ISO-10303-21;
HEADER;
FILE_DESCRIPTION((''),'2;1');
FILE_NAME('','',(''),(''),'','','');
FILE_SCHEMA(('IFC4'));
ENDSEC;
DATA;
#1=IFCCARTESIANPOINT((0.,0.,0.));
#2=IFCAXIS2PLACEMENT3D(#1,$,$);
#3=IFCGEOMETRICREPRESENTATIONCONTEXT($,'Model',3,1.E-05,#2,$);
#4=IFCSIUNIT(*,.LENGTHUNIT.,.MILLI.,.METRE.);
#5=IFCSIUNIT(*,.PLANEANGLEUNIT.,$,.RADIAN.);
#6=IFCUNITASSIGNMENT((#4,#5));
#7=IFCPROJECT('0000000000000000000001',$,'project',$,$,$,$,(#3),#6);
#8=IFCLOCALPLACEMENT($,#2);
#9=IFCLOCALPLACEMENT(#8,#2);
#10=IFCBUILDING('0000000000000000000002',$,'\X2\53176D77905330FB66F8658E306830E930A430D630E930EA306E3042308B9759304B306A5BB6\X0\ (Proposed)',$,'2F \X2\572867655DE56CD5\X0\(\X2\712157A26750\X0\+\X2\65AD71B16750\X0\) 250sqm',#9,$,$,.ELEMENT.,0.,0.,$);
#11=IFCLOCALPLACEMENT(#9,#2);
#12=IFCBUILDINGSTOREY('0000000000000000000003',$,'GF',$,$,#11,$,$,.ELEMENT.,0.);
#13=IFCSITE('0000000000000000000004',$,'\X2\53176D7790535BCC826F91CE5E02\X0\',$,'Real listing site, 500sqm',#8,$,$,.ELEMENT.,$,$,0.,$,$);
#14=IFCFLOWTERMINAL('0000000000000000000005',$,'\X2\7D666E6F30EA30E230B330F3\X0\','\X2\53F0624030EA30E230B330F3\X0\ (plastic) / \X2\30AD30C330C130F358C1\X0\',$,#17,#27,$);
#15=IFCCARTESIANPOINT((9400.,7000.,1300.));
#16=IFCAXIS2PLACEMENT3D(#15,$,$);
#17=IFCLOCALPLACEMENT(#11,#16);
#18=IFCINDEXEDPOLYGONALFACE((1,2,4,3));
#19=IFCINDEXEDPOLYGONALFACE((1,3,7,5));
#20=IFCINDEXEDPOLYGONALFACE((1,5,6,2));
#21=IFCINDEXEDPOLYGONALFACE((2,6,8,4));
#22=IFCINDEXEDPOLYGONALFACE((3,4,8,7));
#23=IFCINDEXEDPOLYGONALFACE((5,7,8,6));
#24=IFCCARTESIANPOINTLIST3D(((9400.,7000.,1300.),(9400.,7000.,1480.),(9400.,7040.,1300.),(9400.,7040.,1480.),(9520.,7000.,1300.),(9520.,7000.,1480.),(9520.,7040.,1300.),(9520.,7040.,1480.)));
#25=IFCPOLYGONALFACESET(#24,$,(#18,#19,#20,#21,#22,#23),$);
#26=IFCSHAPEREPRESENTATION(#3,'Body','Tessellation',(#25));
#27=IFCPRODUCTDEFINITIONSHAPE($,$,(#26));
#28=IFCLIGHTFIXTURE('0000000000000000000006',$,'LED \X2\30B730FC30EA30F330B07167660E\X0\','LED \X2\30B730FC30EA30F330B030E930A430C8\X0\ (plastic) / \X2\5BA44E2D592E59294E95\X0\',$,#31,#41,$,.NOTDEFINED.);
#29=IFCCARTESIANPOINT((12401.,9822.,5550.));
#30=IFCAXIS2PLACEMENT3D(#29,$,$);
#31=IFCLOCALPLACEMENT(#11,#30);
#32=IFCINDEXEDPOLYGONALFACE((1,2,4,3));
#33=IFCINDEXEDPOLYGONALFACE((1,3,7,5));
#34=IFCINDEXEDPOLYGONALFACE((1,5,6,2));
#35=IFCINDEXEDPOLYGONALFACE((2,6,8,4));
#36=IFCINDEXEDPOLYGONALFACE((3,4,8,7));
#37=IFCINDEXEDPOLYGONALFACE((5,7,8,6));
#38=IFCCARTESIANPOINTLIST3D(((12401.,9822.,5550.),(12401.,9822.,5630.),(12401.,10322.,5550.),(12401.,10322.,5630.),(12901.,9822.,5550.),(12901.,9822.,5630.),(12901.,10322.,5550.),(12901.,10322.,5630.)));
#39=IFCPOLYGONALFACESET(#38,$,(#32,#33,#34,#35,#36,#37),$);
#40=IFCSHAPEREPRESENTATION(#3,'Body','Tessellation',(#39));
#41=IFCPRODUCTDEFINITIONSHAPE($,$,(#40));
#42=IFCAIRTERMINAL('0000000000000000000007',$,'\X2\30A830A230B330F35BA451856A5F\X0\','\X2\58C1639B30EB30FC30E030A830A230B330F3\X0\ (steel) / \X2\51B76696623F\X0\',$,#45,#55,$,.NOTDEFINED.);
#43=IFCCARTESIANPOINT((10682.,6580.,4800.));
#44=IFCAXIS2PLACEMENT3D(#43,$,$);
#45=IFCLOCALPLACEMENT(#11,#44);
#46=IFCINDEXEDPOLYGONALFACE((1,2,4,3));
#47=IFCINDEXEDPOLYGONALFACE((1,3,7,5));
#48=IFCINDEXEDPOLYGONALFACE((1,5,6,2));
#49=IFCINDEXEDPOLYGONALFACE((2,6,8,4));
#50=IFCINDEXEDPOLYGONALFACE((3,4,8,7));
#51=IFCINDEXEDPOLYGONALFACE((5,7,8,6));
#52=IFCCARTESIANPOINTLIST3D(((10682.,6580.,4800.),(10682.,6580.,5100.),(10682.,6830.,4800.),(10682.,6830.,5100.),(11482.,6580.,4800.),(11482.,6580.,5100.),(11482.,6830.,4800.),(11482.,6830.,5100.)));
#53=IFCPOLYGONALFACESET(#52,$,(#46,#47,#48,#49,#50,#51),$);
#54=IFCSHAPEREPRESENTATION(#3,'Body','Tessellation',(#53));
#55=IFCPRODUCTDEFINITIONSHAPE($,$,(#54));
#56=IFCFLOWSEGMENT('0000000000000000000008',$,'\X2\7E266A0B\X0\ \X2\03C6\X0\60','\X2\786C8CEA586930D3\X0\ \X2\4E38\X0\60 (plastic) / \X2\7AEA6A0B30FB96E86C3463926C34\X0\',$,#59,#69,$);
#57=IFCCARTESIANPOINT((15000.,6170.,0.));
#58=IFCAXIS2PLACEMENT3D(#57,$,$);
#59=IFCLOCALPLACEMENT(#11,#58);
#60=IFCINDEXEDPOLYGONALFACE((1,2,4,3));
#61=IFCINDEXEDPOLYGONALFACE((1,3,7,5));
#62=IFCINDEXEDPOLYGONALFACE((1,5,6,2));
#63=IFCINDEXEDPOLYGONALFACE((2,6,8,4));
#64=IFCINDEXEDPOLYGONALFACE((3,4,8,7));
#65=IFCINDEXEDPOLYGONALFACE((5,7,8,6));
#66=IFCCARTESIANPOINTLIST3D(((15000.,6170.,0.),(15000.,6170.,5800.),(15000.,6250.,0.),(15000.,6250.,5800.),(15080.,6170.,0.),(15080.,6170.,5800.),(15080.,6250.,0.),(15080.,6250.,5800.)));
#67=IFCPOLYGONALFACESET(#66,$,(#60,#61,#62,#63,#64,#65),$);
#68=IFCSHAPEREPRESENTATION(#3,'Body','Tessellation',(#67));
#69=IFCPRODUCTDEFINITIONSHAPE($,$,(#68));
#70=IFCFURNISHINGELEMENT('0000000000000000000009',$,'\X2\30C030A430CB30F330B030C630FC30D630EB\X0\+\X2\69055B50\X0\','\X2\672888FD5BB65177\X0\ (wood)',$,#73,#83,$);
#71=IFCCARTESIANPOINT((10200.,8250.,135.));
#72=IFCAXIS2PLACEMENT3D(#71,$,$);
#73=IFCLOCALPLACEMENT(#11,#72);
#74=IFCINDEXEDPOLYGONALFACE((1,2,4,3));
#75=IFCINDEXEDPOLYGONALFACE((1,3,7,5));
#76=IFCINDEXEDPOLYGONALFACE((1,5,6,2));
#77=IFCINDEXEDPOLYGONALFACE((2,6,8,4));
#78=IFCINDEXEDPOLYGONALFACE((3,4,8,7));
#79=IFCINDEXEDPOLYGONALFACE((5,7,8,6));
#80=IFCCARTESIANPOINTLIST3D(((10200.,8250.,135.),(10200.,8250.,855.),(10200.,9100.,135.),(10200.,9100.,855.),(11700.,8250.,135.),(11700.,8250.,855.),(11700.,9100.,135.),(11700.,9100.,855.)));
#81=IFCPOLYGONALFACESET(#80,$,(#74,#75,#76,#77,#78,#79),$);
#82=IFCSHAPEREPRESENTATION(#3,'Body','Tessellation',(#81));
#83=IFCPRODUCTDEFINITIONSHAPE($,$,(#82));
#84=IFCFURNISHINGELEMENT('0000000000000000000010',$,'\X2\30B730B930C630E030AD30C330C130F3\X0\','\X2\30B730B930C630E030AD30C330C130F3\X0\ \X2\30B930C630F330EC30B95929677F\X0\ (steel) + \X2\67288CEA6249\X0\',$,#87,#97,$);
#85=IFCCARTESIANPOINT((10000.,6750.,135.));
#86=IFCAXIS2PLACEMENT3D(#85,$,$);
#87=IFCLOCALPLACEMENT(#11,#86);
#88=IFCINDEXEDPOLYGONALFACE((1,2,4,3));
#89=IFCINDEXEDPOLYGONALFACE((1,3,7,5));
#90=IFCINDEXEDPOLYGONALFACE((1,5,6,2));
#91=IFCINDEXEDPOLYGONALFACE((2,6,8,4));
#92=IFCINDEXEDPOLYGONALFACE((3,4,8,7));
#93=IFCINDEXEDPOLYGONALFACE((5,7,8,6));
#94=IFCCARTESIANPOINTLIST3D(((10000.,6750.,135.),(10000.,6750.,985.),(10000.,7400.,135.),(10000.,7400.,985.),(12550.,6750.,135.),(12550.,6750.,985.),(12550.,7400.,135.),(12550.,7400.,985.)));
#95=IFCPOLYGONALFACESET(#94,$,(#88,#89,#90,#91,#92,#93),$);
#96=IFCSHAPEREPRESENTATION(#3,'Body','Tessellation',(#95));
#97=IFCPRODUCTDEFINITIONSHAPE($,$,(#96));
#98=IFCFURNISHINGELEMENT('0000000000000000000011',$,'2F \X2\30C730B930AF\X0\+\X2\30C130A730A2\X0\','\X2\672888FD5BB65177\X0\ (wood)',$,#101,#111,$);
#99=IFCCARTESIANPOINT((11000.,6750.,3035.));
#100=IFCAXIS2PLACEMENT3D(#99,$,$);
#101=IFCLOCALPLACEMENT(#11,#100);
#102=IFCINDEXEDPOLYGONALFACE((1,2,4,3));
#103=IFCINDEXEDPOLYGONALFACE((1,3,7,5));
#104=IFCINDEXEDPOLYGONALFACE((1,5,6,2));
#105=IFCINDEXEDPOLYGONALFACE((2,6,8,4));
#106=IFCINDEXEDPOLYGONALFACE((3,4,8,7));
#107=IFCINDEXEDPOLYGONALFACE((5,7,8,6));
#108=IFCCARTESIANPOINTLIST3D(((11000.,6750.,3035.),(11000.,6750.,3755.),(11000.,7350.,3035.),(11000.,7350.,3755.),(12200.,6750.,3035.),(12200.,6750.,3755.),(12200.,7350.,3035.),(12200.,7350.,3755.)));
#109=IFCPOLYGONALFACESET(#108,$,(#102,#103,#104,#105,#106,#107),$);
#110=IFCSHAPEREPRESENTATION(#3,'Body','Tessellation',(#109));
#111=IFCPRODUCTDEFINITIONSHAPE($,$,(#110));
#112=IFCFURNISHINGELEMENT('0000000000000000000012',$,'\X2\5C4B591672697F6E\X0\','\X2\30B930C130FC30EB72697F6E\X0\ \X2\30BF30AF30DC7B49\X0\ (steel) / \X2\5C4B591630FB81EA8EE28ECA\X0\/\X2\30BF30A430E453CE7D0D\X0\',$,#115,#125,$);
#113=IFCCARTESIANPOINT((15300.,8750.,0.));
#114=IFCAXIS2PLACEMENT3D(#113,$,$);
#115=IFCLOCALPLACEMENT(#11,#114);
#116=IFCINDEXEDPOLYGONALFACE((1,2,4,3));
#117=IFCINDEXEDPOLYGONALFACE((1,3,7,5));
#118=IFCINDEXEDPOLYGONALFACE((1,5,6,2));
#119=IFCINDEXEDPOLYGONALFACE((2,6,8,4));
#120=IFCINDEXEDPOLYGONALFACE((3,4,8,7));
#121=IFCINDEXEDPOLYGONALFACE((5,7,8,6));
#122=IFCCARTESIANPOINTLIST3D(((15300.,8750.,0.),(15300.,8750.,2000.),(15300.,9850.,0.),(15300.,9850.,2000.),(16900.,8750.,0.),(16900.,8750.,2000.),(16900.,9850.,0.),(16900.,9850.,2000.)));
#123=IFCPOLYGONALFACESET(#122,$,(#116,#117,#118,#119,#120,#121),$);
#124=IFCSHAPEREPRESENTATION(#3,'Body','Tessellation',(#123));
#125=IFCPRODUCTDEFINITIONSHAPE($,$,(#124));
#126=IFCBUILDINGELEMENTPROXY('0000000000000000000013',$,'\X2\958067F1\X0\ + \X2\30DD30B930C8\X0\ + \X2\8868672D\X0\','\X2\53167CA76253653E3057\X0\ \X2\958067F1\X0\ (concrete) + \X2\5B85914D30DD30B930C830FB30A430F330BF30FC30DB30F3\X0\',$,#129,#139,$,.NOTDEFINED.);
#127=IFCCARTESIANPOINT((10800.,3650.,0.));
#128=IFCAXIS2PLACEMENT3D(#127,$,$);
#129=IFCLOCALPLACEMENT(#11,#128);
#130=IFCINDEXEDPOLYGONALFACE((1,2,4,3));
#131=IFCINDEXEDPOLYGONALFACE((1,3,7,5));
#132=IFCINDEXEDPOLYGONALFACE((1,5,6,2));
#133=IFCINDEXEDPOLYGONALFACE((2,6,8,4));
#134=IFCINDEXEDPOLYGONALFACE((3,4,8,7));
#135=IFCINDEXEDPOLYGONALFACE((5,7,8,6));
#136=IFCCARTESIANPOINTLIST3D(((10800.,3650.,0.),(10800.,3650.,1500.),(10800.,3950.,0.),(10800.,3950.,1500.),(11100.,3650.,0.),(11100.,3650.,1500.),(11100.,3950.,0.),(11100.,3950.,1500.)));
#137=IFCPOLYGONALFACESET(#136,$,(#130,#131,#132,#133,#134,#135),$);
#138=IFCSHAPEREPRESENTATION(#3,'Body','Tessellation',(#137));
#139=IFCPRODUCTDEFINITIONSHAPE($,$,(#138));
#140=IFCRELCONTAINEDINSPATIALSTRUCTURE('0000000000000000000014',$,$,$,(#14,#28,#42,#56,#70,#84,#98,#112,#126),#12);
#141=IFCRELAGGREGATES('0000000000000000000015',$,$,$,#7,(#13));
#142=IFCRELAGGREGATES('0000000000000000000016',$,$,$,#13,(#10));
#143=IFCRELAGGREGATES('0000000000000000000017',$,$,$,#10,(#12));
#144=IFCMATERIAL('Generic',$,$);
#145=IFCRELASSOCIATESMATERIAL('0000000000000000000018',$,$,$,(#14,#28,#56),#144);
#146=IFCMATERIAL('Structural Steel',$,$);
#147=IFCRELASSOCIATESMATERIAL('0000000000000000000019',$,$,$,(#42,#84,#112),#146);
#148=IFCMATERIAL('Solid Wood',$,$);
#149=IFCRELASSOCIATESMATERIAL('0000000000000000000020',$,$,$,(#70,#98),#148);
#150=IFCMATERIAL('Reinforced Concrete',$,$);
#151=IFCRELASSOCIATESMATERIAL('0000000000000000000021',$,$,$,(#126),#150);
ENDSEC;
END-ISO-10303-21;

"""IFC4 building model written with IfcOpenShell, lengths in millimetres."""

from ifc_helpers import new_model, si_unit, frame, frame_2d, origin, place, context, project, spatial, rectangle, extrude, material, element, save


model = new_model("IFC4")

# Units and contexts
model_context = context("Model", 3, precision=1e-05, world=origin())
ifc_project = project(units=[si_unit("LENGTHUNIT", "METRE", prefix="MILLI"), si_unit("PLANEANGLEUNIT", "RADIAN")], contexts=[model_context])

# Site, building, storey
site_placement = place(None, origin())
site = spatial("IfcSite", under=ifc_project, at=site_placement, Name="北海道富良野市", ObjectType="Real listing site, 500sqm", CompositionType="ELEMENT", RefElevation=0.0)
building_placement = place(site_placement, origin())
building = spatial("IfcBuilding", under=site, at=building_placement, Name="北海道・書斎とライブラリのある静かな家 (Proposed)", ObjectType="2F 在来工法(無垢材+断熱材) 250sqm", CompositionType="ELEMENT", ElevationOfRefHeight=0.0, ElevationOfTerrain=0.0)
storey_placement = place(building_placement, origin())
storey = spatial("IfcBuildingStorey", under=building, at=storey_placement, Name="GF", CompositionType="ELEMENT", Elevation=0.0)

# Shared definitions
ifc_material_1 = material(Name="Solid Wood")

# Shared definitions
ifc_material_2 = material(Name="Reinforced Concrete")

# Shared definitions
ifc_material_3 = material(Name="Structural Steel")

# Flow terminal
ifc_material_4 = material(Name="Generic")
flow_terminal_1_placement = place(storey_placement, frame((9400.0, 7000.0, 1300.0)))
element("IfcFlowTerminal", 1, at=flow_terminal_1_placement, inside=storey, material=ifc_material_4, Name="給湯リモコン", Description="台所リモコン (plastic) / キッチン壁", context=model_context, shape_type="SweptSolid", body=[
    extrude(rectangle(XDim=120.0, YDim=40.0, at=frame_2d((60.0, 20.0))), frame((9400.0, 7000.0, 1300.0)), (0.0, 0.0, 1.0), 180.0),
])

# Light fixture
light_fixture_placement = place(storey_placement, frame((12401.0, 9822.0, 5550.0)))
element("IfcLightFixture", 2, at=light_fixture_placement, inside=storey, material=ifc_material_4, Name="LED シーリング照明", Description="LED シーリングライト (plastic) / 室中央天井", PredefinedType="NOTDEFINED", context=model_context, shape_type="SweptSolid", body=[
    extrude(rectangle(XDim=500.0, YDim=500.0, at=frame_2d((250.0, 250.0))), frame((12401.0, 9822.0, 5550.0)), (0.0, 0.0, 1.0), 80.0),
])

# Air terminal
air_terminal_placement = place(storey_placement, frame((10682.0, 6580.0, 4800.0)))
element("IfcAirTerminal", 3, at=air_terminal_placement, inside=storey, material=ifc_material_3, Name="エアコン室内機", Description="壁掛ルームエアコン (steel) / 冷暖房", PredefinedType="NOTDEFINED", context=model_context, shape_type="SweptSolid", body=[
    extrude(rectangle(XDim=800.0, YDim=250.0, at=frame_2d((400.0, 125.0))), frame((10682.0, 6580.0, 4800.0)), (0.0, 0.0, 1.0), 300.0),
])

# Flow segment
flow_segment_placement = place(storey_placement, frame((15000.0, 6170.0, 0.0)))
element("IfcFlowSegment", 4, at=flow_segment_placement, inside=storey, material=ifc_material_4, Name="縦樋 φ60", Description="硬質塩ビ 丸60 (plastic) / 竪樋・雨水排水", context=model_context, shape_type="SweptSolid", body=[
    extrude(rectangle(XDim=80.0, YDim=80.0, at=frame_2d((40.0, 40.0))), frame((15000.0, 6170.0, 0.0)), (0.0, 0.0, 1.0), 5800.0),
])

# Furnishing elements
furnishing_1_placement = place(storey_placement, frame((10200.0, 8250.0, 135.0)))
element("IfcFurnishingElement", 5, at=furnishing_1_placement, inside=storey, material=ifc_material_1, Name="ダイニングテーブル+椅子", Description="木製家具 (wood)", context=model_context, shape_type="SweptSolid", body=[
    extrude(rectangle(XDim=1500.0, YDim=850.0, at=frame_2d((750.0, 425.0))), frame((10200.0, 8250.0, 135.0)), (0.0, 0.0, 1.0), 720.0),
])
furnishing_2_placement = place(storey_placement, frame((10000.0, 6750.0, 135.0)))
element("IfcFurnishingElement", 6, at=furnishing_2_placement, inside=storey, material=ifc_material_3, Name="システムキッチン", Description="システムキッチン ステンレス天板 (steel) + 木質扉", context=model_context, shape_type="SweptSolid", body=[
    extrude(rectangle(XDim=2550.0, YDim=650.0, at=frame_2d((1275.0, 325.0))), frame((10000.0, 6750.0, 135.0)), (0.0, 0.0, 1.0), 850.0),
])
furnishing_3_placement = place(storey_placement, frame((11000.0, 6750.0, 3035.0)))
element("IfcFurnishingElement", 7, at=furnishing_3_placement, inside=storey, material=ifc_material_1, Name="2F デスク+チェア", Description="木製家具 (wood)", context=model_context, shape_type="SweptSolid", body=[
    extrude(rectangle(XDim=1200.0, YDim=600.0, at=frame_2d((600.0, 300.0))), frame((11000.0, 6750.0, 3035.0)), (0.0, 0.0, 1.0), 720.0),
])
furnishing_4_placement = place(storey_placement, frame((15300.0, 8750.0, 0.0)))
element("IfcFurnishingElement", 8, at=furnishing_4_placement, inside=storey, material=ifc_material_3, Name="屋外物置", Description="スチール物置 タクボ等 (steel) / 屋外・自転車/タイヤ収納", context=model_context, shape_type="SweptSolid", body=[
    extrude(rectangle(XDim=1600.0, YDim=1100.0, at=frame_2d((800.0, 550.0))), frame((15300.0, 8750.0, 0.0)), (0.0, 0.0, 1.0), 2000.0),
])

# Building element proxy
proxy_placement = place(storey_placement, frame((10800.0, 3650.0, 0.0)))
element("IfcBuildingElementProxy", 9, at=proxy_placement, inside=storey, material=ifc_material_2, Name="門柱 + ポスト + 表札", Description="化粧打放し 門柱 (concrete) + 宅配ポスト・インターホン", PredefinedType="NOTDEFINED", context=model_context, shape_type="SweptSolid", body=[
    extrude(rectangle(XDim=300.0, YDim=300.0, at=frame_2d((150.0, 150.0))), frame((10800.0, 3650.0, 0.0)), (0.0, 0.0, 1.0), 1500.0),
])

save(model, "model.ifc")
